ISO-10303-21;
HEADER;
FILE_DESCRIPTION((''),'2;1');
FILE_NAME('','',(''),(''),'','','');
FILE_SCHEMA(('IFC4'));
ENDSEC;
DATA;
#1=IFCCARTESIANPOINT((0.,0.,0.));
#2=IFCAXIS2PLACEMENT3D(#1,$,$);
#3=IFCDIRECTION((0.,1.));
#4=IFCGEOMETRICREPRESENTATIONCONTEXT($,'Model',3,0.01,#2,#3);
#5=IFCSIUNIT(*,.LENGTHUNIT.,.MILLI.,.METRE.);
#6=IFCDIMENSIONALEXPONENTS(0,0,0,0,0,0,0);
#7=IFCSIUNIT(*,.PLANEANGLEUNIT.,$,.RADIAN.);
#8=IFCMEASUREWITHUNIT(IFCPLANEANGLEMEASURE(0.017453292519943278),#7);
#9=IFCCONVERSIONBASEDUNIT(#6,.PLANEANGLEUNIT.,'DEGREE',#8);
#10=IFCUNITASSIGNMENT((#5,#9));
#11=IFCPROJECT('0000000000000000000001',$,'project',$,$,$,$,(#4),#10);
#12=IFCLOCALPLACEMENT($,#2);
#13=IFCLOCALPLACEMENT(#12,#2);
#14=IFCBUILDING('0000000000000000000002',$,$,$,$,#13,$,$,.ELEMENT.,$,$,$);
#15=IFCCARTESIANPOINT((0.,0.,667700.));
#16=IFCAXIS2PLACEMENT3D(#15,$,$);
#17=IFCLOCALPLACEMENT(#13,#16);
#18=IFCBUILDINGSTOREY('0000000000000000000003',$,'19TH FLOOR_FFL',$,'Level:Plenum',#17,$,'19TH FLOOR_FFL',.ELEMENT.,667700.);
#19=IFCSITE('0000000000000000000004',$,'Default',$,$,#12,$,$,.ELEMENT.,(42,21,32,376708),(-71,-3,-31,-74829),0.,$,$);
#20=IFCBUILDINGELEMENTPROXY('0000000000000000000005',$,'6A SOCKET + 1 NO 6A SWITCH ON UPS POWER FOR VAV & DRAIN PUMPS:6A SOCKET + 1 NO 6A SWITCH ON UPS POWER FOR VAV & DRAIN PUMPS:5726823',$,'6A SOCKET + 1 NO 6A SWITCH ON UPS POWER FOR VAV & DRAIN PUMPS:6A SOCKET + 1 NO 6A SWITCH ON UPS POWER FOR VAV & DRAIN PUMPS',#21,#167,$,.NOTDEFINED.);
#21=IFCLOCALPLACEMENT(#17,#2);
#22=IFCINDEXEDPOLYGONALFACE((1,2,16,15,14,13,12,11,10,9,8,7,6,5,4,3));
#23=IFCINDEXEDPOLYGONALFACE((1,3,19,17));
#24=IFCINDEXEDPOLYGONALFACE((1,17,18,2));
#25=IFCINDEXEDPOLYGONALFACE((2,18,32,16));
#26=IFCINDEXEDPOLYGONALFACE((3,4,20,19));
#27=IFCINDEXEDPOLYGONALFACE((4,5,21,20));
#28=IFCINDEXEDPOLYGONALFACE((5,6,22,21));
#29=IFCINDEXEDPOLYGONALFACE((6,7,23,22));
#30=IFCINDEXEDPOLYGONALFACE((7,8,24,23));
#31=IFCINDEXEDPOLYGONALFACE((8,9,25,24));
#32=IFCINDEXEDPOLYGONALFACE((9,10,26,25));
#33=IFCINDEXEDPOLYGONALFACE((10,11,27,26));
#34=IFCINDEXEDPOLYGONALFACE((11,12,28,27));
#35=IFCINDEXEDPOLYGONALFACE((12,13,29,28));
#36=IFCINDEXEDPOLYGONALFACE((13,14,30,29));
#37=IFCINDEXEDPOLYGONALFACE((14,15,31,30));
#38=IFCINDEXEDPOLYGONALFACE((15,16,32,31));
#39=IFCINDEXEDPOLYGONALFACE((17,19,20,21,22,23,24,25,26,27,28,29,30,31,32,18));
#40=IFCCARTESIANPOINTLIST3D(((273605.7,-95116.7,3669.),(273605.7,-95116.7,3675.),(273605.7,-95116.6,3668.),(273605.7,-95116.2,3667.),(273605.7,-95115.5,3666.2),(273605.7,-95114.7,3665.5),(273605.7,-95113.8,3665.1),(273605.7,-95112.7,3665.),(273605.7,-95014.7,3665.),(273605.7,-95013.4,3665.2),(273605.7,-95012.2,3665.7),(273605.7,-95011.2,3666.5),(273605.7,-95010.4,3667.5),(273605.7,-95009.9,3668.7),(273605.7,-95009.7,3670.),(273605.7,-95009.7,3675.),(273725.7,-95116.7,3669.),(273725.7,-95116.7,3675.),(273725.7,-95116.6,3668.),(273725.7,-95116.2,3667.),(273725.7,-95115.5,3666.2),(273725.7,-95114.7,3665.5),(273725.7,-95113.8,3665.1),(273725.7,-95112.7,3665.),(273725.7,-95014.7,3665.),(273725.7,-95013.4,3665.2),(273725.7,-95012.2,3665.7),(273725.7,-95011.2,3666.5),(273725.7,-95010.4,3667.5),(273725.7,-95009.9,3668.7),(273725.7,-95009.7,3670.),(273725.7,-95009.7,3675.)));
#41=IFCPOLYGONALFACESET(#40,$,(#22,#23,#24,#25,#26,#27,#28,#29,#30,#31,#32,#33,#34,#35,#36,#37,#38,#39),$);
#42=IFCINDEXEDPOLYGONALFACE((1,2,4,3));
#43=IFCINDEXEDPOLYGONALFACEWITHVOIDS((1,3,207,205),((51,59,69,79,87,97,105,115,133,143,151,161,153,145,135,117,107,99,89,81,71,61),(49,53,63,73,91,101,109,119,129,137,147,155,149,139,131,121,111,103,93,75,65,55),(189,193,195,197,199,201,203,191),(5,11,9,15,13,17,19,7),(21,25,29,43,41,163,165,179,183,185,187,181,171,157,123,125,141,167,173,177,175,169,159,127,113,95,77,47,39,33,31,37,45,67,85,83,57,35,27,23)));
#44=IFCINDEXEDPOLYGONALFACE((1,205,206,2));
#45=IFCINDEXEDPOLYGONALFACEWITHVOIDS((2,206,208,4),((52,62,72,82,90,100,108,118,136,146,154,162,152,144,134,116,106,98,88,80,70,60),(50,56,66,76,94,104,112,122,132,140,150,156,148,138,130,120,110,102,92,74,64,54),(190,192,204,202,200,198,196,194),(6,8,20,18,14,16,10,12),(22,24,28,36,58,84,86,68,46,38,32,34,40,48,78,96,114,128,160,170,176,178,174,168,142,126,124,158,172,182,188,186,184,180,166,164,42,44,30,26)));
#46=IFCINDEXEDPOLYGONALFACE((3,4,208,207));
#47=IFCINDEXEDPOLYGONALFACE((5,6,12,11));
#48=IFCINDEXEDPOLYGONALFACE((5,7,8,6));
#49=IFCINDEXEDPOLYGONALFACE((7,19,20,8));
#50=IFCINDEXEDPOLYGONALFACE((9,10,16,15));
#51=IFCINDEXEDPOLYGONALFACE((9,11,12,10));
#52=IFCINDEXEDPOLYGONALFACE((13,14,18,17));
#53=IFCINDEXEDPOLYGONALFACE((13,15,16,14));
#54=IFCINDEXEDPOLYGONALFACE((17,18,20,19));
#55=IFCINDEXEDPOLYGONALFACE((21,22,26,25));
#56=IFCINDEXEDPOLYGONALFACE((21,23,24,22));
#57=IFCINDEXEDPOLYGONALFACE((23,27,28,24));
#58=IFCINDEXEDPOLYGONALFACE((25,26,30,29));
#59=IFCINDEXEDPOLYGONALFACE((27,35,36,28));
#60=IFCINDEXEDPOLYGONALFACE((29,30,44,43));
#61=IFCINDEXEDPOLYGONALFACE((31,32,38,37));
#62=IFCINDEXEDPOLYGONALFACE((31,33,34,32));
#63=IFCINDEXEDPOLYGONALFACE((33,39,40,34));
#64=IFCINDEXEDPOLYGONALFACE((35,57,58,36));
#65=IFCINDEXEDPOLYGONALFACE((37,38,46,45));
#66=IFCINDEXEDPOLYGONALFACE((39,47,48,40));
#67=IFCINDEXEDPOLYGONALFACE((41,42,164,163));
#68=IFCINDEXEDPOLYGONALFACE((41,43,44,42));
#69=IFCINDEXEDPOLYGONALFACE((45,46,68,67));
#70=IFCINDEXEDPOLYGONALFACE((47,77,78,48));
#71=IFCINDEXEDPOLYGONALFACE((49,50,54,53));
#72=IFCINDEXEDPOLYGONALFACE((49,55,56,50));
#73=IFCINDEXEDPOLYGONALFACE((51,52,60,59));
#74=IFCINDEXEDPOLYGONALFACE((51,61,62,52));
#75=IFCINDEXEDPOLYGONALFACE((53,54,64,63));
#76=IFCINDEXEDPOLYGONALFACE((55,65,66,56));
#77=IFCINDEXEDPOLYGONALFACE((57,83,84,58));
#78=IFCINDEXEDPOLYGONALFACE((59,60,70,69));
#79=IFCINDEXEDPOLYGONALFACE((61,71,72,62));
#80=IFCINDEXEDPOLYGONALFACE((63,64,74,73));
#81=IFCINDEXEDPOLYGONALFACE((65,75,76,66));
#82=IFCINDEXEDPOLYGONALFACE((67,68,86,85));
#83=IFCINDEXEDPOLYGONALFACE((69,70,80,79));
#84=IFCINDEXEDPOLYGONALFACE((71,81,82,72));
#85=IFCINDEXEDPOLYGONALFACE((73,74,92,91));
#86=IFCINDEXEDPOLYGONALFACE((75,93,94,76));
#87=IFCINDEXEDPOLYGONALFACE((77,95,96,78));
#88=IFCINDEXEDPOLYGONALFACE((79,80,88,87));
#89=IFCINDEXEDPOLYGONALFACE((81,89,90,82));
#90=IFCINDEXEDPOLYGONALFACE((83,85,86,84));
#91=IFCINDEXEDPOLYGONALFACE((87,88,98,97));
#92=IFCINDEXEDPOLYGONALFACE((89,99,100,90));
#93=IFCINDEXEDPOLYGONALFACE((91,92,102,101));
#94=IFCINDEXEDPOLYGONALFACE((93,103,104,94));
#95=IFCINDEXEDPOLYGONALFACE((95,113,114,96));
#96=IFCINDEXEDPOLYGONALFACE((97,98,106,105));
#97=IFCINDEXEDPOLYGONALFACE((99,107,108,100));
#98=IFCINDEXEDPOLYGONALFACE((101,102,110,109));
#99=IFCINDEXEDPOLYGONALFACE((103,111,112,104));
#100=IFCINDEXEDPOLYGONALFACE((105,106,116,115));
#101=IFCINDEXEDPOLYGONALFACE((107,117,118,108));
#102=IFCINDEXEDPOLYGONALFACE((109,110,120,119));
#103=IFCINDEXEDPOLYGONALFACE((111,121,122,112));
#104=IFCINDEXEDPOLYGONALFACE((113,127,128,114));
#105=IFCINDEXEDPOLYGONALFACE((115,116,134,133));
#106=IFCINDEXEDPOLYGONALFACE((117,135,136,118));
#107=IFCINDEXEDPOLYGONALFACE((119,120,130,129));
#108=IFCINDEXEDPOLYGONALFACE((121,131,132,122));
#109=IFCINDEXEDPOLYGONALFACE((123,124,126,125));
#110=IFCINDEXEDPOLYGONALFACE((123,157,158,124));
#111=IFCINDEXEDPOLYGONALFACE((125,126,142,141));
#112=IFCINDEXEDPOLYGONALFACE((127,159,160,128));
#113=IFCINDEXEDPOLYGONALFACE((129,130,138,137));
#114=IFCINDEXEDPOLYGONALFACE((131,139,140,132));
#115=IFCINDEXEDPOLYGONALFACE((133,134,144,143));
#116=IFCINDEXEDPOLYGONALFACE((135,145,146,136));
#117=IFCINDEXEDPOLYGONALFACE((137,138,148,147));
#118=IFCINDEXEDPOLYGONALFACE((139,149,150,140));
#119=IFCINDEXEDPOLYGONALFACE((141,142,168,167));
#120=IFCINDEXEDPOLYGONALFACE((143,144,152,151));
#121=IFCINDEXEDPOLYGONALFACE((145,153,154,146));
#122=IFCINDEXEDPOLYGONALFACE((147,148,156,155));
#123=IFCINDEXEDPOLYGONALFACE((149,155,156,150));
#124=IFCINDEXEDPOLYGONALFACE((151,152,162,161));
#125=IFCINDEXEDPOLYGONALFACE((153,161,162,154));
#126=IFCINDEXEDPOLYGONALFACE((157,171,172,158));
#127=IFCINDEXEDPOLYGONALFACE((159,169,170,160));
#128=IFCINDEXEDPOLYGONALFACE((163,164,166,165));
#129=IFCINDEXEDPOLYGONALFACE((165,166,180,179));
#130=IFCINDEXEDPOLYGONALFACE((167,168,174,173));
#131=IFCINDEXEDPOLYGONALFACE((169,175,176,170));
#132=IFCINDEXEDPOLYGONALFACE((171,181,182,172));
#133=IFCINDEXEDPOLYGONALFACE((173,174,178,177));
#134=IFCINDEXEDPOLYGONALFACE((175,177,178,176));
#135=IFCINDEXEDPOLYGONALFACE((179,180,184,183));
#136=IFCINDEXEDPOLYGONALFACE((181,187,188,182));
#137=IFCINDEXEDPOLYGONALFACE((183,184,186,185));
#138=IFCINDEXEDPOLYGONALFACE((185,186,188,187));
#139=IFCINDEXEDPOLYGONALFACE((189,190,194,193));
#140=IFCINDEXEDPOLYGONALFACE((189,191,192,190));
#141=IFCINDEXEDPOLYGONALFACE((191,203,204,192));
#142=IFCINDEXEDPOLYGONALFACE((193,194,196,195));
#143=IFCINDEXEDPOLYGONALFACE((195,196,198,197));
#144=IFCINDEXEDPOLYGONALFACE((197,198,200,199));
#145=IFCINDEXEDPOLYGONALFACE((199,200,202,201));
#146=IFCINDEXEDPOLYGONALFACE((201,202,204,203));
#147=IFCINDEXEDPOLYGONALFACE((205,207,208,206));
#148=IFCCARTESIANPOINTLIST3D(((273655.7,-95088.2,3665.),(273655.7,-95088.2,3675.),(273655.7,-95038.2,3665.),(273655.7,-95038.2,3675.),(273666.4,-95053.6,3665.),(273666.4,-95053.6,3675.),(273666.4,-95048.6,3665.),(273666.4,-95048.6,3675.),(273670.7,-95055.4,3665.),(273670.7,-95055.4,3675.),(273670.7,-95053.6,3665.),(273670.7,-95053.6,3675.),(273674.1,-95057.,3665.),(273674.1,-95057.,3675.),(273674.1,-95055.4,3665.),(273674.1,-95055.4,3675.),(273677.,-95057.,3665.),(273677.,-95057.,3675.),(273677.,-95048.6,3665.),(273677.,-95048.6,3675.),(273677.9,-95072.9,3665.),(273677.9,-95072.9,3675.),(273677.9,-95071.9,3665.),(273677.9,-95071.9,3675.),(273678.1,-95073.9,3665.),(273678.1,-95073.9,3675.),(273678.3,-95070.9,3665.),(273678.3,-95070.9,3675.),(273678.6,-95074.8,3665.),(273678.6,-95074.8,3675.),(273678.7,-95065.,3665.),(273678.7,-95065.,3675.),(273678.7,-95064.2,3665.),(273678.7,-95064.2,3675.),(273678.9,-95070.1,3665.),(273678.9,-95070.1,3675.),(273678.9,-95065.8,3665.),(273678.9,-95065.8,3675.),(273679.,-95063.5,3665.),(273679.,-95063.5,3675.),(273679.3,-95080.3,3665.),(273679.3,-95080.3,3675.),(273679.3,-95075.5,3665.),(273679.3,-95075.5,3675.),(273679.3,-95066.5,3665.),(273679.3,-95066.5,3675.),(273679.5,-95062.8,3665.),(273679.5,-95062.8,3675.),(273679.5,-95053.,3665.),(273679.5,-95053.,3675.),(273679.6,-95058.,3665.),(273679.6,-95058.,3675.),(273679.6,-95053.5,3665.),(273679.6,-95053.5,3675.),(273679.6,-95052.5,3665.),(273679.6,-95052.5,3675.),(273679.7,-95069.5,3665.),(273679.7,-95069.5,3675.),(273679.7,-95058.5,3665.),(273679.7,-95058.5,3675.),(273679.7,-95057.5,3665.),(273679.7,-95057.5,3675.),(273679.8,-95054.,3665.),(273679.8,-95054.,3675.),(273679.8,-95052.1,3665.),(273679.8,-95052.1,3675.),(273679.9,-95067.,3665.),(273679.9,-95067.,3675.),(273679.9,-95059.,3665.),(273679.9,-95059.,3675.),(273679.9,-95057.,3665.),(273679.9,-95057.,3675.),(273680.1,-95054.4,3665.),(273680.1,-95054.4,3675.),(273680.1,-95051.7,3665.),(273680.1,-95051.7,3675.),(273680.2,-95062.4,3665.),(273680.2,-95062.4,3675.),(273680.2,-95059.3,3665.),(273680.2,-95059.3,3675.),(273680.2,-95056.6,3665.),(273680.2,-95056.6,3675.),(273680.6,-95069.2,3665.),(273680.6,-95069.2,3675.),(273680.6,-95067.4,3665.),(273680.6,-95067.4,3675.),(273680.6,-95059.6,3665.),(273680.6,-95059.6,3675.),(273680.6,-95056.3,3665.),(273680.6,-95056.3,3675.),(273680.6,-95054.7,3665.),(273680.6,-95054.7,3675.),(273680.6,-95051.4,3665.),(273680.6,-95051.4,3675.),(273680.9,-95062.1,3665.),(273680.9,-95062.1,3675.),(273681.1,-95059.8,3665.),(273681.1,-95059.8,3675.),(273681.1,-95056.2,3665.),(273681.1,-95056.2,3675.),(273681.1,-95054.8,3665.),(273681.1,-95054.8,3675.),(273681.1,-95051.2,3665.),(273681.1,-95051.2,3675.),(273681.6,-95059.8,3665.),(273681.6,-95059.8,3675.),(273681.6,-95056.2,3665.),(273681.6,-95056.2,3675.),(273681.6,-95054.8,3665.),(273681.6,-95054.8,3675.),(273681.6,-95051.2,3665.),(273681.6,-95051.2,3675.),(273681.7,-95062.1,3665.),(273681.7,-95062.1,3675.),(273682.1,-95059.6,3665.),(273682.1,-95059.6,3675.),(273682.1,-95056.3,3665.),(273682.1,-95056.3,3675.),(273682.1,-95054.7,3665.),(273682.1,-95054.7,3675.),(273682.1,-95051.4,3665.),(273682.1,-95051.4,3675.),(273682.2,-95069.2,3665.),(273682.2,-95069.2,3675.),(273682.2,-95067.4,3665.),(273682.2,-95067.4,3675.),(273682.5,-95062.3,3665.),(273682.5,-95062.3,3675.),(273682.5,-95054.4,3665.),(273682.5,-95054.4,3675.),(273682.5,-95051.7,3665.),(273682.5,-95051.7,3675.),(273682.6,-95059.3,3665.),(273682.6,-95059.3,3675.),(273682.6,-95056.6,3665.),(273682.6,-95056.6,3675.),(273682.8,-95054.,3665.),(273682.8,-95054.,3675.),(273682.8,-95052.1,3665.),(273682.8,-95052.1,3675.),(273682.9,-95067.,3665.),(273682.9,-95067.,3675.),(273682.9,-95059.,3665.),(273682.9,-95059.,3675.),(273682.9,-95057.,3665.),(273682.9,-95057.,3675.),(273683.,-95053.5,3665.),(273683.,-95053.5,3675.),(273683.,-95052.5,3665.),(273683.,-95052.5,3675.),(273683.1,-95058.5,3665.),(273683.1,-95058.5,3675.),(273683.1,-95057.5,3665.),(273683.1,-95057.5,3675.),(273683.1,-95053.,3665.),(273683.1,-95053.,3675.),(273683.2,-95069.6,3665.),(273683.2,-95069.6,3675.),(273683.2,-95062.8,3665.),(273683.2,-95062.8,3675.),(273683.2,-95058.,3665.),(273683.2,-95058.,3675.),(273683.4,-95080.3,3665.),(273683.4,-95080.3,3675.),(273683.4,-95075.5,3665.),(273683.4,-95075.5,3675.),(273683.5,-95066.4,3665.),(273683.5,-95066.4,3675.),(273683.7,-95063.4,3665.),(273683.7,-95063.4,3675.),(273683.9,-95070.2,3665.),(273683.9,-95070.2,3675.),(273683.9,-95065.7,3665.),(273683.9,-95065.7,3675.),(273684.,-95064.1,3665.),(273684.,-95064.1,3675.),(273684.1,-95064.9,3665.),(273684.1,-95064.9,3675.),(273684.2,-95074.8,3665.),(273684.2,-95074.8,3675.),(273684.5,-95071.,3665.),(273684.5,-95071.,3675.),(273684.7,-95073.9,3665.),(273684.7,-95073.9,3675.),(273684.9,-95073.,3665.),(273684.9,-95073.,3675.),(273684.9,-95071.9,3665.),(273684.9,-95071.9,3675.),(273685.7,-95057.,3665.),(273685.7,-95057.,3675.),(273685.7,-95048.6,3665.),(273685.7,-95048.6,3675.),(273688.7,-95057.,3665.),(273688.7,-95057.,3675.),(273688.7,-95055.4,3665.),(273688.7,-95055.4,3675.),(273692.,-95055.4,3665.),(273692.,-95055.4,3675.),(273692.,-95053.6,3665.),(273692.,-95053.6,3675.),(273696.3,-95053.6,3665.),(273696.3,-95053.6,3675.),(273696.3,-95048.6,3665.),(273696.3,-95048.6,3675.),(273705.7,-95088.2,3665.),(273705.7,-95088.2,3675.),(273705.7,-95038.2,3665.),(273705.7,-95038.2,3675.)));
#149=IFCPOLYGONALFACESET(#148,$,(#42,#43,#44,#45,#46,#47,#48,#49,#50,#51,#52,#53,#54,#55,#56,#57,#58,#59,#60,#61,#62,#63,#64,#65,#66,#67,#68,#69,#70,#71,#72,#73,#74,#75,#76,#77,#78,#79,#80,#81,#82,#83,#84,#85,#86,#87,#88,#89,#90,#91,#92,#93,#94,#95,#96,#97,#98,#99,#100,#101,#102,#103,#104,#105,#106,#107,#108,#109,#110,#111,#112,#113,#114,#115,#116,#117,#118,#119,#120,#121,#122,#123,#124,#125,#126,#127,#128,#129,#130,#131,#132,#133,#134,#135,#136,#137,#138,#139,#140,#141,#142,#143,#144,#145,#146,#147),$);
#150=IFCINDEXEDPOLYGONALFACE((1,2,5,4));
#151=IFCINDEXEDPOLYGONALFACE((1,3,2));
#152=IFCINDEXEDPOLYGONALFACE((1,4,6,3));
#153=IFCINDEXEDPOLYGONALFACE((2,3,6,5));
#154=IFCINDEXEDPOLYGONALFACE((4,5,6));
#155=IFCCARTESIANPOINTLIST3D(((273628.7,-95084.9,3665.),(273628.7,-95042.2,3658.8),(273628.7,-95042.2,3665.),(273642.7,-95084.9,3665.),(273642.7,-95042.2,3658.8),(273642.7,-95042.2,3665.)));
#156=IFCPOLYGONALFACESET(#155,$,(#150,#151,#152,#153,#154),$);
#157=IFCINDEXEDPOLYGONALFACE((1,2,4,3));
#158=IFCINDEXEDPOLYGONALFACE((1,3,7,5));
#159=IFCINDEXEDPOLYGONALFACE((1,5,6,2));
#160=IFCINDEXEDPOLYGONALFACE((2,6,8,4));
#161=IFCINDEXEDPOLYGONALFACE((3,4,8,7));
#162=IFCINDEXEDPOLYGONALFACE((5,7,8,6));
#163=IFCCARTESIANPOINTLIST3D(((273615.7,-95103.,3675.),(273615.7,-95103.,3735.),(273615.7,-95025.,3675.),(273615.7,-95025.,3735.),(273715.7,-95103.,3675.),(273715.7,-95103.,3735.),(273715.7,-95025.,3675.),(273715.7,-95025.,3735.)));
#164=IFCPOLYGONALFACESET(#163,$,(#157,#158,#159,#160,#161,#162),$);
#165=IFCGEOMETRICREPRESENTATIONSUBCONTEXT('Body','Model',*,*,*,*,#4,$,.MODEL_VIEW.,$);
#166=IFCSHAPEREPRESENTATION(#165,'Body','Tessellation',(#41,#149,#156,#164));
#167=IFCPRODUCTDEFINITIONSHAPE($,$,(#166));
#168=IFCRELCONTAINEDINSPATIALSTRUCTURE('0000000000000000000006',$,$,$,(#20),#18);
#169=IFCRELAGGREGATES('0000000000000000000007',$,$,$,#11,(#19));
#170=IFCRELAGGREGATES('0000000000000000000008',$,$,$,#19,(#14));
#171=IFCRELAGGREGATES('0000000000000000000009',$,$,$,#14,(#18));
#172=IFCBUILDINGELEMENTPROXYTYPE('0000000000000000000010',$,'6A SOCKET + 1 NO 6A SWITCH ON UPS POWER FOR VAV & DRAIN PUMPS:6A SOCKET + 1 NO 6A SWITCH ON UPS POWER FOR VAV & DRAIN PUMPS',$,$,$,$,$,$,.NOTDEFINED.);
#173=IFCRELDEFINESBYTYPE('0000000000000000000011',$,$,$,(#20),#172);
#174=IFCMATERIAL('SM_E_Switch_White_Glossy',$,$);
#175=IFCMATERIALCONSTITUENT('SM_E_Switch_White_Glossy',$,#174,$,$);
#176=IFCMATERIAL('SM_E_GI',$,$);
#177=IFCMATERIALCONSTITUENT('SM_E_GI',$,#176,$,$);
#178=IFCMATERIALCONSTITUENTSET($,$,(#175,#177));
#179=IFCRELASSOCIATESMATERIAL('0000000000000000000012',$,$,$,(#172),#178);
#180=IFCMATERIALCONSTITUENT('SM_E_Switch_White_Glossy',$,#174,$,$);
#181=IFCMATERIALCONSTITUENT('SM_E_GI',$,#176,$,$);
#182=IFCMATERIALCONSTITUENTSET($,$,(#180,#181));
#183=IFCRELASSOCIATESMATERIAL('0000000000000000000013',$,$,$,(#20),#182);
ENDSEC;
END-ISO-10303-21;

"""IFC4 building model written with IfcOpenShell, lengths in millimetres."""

from ifc_helpers import new_model, entity, si_unit, converted_unit, direction, frame, origin, place, context, subcontext, project, spatial, line, arc, indexed_curve, outline, extrude, source, transform, mapped, material, constituent, constituent_set, type_object, type_shapes, element, save


model = new_model("IFC4")

# Units and contexts
model_context = context("Model", 3, precision=0.01, world=origin(), true_north=direction((0.0, 1.0)))
body_context = subcontext(model_context, "Body", "Model", "MODEL_VIEW")
ifc_project = project(units=[si_unit("LENGTHUNIT", "METRE", prefix="MILLI"), converted_unit("PLANEANGLEUNIT", "DEGREE", entity("IfcPlaneAngleMeasure", 0.017453292519943278), si_unit("PLANEANGLEUNIT", "RADIAN"), dimensions=[0, 0, 0, 0, 0, 0, 0])], contexts=[model_context])

# Site, building, storey
site_placement = place(None, origin())
site = spatial("IfcSite", under=ifc_project, at=site_placement, Name="Default", CompositionType="ELEMENT", RefLatitude=(42, 21, 32, 376708), RefLongitude=(-71, -3, -31, -74829), RefElevation=0.0)
building_placement = place(site_placement, origin())
building = spatial("IfcBuilding", under=site, at=building_placement, CompositionType="ELEMENT")
storey_placement = place(building_placement, frame((0.0, 0.0, 667700.0)))
storey = spatial("IfcBuildingStorey", under=building, at=storey_placement, Name="19TH FLOOR_FFL", ObjectType="Level:Plenum", LongName="19TH FLOOR_FFL", CompositionType="ELEMENT", Elevation=667700.0)

# Shared definitions
ifc_material_1 = material(Name="SM_E_Switch_White_Glossy")
ifc_material_2 = material(Name="SM_E_GI")

# Building element proxy
ifc_constituent_1 = constituent(ifc_material_1, Name="SM_E_Switch_White_Glossy")
ifc_constituent_2 = constituent(ifc_material_2, Name="SM_E_GI")
ifc_constituent_set_1 = constituent_set(constituents=[ifc_constituent_1, ifc_constituent_2])
ifc_constituent_3 = constituent(ifc_material_1, Name="SM_E_Switch_White_Glossy")
ifc_constituent_4 = constituent(ifc_material_2, Name="SM_E_GI")
ifc_constituent_set_2 = constituent_set(constituents=[ifc_constituent_3, ifc_constituent_4])
building_element_proxy_type_1 = type_object("IfcBuildingElementProxyType", Name="6A SOCKET + 1 NO 6A SWITCH ON UPS POWER FOR VAV & DRAIN PUMPS:6A SOCKET + 1 NO 6A SWITCH ON UPS POWER FOR VAV & DRAIN PUMPS", PredefinedType="NOTDEFINED", material=ifc_constituent_set_2)
shared_shape_1 = source(origin(), body_context, "Body", "SweptSolid", [
    extrude(outline(indexed_curve([(-5.2, -53.7), (-0.2, -53.7), (3.4, -52.2), (4.8, -48.7), (4.8, 49.3), (3.7, 52.2), (0.8, 53.3), (-5.2, 53.3)], segments=[line(1, 2), arc(2, 3, 4), line(4, 5), arc(5, 6, 7), line(7, 8, 1)], self_intersect=False)), frame((-60.0, 53.3, 5.2), z_axis=(1.0, 0.0, 0.0), x_axis=(0.0, 0.0, 1.0)), (0.0, 0.0, 1.0), 120.0),
    extrude(outline(indexed_curve([(-25.0, -25.0), (25.0, -25.0), (25.0, 25.0), (-25.0, 25.0), (-25.0, -25.0)], self_intersect=False), holes=[indexed_curve([(-5.9, -0.1), (-8.7, -2.8), (-12.3, -1.4), (-17.1, -1.4), (-17.1, 2.7), (-12.3, 2.7), (-8.7, 4.1), (-6.0, 1.5), (-4.1, 1.5), (1.1, 0.6), (-4.2, -0.1)], segments=[arc(1, 2, 3), line(3, 4, 5, 6), arc(6, 7, 8), line(8, 9), arc(9, 10, 11), line(11, 1)], self_intersect=False), indexed_curve([(5.2, 2.4), (7.0, 0.6), (5.2, -1.2), (3.4, 0.6)], segments=[arc(1, 2, 3), arc(3, 4, 1)], self_intersect=False), indexed_curve([(10.2, 2.4), (12.0, 0.6), (10.2, -1.2), (8.4, 0.6)], segments=[arc(1, 2, 3), arc(3, 4, 1)], self_intersect=False), indexed_curve([(14.7, 15.6), (14.7, 5.0), (6.3, 5.0), (6.3, 7.9), (7.8, 7.9), (7.8, 11.3), (9.7, 11.3), (9.7, 15.6), (14.7, 15.6)], self_intersect=False), indexed_curve([(14.7, -14.3), (9.7, -14.3), (9.7, -10.0), (7.8, -10.0), (7.8, -6.6), (6.3, -6.6), (6.3, -3.7), (14.7, -3.7), (14.7, -14.3)], self_intersect=False)]), frame((-15.0, 53.5, 0.0), z_axis=(0.0, 0.0, 1.0), x_axis=(0.0, 1.0, 0.0)), (0.0, 0.0, 1.0), 10.0),
    extrude(outline(indexed_curve([(-14.7, -2.0), (28.5, -2.0), (-13.8, 4.1), (-14.7, -2.0)], self_intersect=False)), frame((23.0, 60.3, 12.1), z_axis=(1.0, 0.0, 0.0), x_axis=(0.0, -0.989716, -0.143046)), (0.0, 0.0, 1.0), 14.0),
    extrude(outline(indexed_curve([(-39.0, -50.0), (39.0, -50.0), (39.0, 50.0), (-39.0, 50.0), (-39.0, -50.0)], self_intersect=False)), frame((0.0, 52.8, -60.0), z_axis=(0.0, 0.0, 1.0), x_axis=(0.0, 1.0, 0.0)), (0.0, 0.0, 1.0), 60.0),
])
type_shapes(building_element_proxy_type_1, [shared_shape_1])
proxy_1_placement = place(storey_placement, frame((273665.7, -95116.7, 3675.0), z_axis=(0.0, 0.0, -1.0), x_axis=(-1.0, 0.0, 0.0)))
element("IfcBuildingElementProxy", 1, at=proxy_1_placement, inside=storey, type_object=building_element_proxy_type_1, material=ifc_constituent_set_1, Name="6A SOCKET + 1 NO 6A SWITCH ON UPS POWER FOR VAV & DRAIN PUMPS:6A SOCKET + 1 NO 6A SWITCH ON UPS POWER FOR VAV & DRAIN PUMPS:5726823", ObjectType="6A SOCKET + 1 NO 6A SWITCH ON UPS POWER FOR VAV & DRAIN PUMPS:6A SOCKET + 1 NO 6A SWITCH ON UPS POWER FOR VAV & DRAIN PUMPS", PredefinedType="NOTDEFINED", context=body_context, shape_type="MappedRepresentation", body=[
    mapped(shared_shape_1, transform((0.0, 0.0, 0.0), scale=1.0)),
])

save(model, "model.ifc")
